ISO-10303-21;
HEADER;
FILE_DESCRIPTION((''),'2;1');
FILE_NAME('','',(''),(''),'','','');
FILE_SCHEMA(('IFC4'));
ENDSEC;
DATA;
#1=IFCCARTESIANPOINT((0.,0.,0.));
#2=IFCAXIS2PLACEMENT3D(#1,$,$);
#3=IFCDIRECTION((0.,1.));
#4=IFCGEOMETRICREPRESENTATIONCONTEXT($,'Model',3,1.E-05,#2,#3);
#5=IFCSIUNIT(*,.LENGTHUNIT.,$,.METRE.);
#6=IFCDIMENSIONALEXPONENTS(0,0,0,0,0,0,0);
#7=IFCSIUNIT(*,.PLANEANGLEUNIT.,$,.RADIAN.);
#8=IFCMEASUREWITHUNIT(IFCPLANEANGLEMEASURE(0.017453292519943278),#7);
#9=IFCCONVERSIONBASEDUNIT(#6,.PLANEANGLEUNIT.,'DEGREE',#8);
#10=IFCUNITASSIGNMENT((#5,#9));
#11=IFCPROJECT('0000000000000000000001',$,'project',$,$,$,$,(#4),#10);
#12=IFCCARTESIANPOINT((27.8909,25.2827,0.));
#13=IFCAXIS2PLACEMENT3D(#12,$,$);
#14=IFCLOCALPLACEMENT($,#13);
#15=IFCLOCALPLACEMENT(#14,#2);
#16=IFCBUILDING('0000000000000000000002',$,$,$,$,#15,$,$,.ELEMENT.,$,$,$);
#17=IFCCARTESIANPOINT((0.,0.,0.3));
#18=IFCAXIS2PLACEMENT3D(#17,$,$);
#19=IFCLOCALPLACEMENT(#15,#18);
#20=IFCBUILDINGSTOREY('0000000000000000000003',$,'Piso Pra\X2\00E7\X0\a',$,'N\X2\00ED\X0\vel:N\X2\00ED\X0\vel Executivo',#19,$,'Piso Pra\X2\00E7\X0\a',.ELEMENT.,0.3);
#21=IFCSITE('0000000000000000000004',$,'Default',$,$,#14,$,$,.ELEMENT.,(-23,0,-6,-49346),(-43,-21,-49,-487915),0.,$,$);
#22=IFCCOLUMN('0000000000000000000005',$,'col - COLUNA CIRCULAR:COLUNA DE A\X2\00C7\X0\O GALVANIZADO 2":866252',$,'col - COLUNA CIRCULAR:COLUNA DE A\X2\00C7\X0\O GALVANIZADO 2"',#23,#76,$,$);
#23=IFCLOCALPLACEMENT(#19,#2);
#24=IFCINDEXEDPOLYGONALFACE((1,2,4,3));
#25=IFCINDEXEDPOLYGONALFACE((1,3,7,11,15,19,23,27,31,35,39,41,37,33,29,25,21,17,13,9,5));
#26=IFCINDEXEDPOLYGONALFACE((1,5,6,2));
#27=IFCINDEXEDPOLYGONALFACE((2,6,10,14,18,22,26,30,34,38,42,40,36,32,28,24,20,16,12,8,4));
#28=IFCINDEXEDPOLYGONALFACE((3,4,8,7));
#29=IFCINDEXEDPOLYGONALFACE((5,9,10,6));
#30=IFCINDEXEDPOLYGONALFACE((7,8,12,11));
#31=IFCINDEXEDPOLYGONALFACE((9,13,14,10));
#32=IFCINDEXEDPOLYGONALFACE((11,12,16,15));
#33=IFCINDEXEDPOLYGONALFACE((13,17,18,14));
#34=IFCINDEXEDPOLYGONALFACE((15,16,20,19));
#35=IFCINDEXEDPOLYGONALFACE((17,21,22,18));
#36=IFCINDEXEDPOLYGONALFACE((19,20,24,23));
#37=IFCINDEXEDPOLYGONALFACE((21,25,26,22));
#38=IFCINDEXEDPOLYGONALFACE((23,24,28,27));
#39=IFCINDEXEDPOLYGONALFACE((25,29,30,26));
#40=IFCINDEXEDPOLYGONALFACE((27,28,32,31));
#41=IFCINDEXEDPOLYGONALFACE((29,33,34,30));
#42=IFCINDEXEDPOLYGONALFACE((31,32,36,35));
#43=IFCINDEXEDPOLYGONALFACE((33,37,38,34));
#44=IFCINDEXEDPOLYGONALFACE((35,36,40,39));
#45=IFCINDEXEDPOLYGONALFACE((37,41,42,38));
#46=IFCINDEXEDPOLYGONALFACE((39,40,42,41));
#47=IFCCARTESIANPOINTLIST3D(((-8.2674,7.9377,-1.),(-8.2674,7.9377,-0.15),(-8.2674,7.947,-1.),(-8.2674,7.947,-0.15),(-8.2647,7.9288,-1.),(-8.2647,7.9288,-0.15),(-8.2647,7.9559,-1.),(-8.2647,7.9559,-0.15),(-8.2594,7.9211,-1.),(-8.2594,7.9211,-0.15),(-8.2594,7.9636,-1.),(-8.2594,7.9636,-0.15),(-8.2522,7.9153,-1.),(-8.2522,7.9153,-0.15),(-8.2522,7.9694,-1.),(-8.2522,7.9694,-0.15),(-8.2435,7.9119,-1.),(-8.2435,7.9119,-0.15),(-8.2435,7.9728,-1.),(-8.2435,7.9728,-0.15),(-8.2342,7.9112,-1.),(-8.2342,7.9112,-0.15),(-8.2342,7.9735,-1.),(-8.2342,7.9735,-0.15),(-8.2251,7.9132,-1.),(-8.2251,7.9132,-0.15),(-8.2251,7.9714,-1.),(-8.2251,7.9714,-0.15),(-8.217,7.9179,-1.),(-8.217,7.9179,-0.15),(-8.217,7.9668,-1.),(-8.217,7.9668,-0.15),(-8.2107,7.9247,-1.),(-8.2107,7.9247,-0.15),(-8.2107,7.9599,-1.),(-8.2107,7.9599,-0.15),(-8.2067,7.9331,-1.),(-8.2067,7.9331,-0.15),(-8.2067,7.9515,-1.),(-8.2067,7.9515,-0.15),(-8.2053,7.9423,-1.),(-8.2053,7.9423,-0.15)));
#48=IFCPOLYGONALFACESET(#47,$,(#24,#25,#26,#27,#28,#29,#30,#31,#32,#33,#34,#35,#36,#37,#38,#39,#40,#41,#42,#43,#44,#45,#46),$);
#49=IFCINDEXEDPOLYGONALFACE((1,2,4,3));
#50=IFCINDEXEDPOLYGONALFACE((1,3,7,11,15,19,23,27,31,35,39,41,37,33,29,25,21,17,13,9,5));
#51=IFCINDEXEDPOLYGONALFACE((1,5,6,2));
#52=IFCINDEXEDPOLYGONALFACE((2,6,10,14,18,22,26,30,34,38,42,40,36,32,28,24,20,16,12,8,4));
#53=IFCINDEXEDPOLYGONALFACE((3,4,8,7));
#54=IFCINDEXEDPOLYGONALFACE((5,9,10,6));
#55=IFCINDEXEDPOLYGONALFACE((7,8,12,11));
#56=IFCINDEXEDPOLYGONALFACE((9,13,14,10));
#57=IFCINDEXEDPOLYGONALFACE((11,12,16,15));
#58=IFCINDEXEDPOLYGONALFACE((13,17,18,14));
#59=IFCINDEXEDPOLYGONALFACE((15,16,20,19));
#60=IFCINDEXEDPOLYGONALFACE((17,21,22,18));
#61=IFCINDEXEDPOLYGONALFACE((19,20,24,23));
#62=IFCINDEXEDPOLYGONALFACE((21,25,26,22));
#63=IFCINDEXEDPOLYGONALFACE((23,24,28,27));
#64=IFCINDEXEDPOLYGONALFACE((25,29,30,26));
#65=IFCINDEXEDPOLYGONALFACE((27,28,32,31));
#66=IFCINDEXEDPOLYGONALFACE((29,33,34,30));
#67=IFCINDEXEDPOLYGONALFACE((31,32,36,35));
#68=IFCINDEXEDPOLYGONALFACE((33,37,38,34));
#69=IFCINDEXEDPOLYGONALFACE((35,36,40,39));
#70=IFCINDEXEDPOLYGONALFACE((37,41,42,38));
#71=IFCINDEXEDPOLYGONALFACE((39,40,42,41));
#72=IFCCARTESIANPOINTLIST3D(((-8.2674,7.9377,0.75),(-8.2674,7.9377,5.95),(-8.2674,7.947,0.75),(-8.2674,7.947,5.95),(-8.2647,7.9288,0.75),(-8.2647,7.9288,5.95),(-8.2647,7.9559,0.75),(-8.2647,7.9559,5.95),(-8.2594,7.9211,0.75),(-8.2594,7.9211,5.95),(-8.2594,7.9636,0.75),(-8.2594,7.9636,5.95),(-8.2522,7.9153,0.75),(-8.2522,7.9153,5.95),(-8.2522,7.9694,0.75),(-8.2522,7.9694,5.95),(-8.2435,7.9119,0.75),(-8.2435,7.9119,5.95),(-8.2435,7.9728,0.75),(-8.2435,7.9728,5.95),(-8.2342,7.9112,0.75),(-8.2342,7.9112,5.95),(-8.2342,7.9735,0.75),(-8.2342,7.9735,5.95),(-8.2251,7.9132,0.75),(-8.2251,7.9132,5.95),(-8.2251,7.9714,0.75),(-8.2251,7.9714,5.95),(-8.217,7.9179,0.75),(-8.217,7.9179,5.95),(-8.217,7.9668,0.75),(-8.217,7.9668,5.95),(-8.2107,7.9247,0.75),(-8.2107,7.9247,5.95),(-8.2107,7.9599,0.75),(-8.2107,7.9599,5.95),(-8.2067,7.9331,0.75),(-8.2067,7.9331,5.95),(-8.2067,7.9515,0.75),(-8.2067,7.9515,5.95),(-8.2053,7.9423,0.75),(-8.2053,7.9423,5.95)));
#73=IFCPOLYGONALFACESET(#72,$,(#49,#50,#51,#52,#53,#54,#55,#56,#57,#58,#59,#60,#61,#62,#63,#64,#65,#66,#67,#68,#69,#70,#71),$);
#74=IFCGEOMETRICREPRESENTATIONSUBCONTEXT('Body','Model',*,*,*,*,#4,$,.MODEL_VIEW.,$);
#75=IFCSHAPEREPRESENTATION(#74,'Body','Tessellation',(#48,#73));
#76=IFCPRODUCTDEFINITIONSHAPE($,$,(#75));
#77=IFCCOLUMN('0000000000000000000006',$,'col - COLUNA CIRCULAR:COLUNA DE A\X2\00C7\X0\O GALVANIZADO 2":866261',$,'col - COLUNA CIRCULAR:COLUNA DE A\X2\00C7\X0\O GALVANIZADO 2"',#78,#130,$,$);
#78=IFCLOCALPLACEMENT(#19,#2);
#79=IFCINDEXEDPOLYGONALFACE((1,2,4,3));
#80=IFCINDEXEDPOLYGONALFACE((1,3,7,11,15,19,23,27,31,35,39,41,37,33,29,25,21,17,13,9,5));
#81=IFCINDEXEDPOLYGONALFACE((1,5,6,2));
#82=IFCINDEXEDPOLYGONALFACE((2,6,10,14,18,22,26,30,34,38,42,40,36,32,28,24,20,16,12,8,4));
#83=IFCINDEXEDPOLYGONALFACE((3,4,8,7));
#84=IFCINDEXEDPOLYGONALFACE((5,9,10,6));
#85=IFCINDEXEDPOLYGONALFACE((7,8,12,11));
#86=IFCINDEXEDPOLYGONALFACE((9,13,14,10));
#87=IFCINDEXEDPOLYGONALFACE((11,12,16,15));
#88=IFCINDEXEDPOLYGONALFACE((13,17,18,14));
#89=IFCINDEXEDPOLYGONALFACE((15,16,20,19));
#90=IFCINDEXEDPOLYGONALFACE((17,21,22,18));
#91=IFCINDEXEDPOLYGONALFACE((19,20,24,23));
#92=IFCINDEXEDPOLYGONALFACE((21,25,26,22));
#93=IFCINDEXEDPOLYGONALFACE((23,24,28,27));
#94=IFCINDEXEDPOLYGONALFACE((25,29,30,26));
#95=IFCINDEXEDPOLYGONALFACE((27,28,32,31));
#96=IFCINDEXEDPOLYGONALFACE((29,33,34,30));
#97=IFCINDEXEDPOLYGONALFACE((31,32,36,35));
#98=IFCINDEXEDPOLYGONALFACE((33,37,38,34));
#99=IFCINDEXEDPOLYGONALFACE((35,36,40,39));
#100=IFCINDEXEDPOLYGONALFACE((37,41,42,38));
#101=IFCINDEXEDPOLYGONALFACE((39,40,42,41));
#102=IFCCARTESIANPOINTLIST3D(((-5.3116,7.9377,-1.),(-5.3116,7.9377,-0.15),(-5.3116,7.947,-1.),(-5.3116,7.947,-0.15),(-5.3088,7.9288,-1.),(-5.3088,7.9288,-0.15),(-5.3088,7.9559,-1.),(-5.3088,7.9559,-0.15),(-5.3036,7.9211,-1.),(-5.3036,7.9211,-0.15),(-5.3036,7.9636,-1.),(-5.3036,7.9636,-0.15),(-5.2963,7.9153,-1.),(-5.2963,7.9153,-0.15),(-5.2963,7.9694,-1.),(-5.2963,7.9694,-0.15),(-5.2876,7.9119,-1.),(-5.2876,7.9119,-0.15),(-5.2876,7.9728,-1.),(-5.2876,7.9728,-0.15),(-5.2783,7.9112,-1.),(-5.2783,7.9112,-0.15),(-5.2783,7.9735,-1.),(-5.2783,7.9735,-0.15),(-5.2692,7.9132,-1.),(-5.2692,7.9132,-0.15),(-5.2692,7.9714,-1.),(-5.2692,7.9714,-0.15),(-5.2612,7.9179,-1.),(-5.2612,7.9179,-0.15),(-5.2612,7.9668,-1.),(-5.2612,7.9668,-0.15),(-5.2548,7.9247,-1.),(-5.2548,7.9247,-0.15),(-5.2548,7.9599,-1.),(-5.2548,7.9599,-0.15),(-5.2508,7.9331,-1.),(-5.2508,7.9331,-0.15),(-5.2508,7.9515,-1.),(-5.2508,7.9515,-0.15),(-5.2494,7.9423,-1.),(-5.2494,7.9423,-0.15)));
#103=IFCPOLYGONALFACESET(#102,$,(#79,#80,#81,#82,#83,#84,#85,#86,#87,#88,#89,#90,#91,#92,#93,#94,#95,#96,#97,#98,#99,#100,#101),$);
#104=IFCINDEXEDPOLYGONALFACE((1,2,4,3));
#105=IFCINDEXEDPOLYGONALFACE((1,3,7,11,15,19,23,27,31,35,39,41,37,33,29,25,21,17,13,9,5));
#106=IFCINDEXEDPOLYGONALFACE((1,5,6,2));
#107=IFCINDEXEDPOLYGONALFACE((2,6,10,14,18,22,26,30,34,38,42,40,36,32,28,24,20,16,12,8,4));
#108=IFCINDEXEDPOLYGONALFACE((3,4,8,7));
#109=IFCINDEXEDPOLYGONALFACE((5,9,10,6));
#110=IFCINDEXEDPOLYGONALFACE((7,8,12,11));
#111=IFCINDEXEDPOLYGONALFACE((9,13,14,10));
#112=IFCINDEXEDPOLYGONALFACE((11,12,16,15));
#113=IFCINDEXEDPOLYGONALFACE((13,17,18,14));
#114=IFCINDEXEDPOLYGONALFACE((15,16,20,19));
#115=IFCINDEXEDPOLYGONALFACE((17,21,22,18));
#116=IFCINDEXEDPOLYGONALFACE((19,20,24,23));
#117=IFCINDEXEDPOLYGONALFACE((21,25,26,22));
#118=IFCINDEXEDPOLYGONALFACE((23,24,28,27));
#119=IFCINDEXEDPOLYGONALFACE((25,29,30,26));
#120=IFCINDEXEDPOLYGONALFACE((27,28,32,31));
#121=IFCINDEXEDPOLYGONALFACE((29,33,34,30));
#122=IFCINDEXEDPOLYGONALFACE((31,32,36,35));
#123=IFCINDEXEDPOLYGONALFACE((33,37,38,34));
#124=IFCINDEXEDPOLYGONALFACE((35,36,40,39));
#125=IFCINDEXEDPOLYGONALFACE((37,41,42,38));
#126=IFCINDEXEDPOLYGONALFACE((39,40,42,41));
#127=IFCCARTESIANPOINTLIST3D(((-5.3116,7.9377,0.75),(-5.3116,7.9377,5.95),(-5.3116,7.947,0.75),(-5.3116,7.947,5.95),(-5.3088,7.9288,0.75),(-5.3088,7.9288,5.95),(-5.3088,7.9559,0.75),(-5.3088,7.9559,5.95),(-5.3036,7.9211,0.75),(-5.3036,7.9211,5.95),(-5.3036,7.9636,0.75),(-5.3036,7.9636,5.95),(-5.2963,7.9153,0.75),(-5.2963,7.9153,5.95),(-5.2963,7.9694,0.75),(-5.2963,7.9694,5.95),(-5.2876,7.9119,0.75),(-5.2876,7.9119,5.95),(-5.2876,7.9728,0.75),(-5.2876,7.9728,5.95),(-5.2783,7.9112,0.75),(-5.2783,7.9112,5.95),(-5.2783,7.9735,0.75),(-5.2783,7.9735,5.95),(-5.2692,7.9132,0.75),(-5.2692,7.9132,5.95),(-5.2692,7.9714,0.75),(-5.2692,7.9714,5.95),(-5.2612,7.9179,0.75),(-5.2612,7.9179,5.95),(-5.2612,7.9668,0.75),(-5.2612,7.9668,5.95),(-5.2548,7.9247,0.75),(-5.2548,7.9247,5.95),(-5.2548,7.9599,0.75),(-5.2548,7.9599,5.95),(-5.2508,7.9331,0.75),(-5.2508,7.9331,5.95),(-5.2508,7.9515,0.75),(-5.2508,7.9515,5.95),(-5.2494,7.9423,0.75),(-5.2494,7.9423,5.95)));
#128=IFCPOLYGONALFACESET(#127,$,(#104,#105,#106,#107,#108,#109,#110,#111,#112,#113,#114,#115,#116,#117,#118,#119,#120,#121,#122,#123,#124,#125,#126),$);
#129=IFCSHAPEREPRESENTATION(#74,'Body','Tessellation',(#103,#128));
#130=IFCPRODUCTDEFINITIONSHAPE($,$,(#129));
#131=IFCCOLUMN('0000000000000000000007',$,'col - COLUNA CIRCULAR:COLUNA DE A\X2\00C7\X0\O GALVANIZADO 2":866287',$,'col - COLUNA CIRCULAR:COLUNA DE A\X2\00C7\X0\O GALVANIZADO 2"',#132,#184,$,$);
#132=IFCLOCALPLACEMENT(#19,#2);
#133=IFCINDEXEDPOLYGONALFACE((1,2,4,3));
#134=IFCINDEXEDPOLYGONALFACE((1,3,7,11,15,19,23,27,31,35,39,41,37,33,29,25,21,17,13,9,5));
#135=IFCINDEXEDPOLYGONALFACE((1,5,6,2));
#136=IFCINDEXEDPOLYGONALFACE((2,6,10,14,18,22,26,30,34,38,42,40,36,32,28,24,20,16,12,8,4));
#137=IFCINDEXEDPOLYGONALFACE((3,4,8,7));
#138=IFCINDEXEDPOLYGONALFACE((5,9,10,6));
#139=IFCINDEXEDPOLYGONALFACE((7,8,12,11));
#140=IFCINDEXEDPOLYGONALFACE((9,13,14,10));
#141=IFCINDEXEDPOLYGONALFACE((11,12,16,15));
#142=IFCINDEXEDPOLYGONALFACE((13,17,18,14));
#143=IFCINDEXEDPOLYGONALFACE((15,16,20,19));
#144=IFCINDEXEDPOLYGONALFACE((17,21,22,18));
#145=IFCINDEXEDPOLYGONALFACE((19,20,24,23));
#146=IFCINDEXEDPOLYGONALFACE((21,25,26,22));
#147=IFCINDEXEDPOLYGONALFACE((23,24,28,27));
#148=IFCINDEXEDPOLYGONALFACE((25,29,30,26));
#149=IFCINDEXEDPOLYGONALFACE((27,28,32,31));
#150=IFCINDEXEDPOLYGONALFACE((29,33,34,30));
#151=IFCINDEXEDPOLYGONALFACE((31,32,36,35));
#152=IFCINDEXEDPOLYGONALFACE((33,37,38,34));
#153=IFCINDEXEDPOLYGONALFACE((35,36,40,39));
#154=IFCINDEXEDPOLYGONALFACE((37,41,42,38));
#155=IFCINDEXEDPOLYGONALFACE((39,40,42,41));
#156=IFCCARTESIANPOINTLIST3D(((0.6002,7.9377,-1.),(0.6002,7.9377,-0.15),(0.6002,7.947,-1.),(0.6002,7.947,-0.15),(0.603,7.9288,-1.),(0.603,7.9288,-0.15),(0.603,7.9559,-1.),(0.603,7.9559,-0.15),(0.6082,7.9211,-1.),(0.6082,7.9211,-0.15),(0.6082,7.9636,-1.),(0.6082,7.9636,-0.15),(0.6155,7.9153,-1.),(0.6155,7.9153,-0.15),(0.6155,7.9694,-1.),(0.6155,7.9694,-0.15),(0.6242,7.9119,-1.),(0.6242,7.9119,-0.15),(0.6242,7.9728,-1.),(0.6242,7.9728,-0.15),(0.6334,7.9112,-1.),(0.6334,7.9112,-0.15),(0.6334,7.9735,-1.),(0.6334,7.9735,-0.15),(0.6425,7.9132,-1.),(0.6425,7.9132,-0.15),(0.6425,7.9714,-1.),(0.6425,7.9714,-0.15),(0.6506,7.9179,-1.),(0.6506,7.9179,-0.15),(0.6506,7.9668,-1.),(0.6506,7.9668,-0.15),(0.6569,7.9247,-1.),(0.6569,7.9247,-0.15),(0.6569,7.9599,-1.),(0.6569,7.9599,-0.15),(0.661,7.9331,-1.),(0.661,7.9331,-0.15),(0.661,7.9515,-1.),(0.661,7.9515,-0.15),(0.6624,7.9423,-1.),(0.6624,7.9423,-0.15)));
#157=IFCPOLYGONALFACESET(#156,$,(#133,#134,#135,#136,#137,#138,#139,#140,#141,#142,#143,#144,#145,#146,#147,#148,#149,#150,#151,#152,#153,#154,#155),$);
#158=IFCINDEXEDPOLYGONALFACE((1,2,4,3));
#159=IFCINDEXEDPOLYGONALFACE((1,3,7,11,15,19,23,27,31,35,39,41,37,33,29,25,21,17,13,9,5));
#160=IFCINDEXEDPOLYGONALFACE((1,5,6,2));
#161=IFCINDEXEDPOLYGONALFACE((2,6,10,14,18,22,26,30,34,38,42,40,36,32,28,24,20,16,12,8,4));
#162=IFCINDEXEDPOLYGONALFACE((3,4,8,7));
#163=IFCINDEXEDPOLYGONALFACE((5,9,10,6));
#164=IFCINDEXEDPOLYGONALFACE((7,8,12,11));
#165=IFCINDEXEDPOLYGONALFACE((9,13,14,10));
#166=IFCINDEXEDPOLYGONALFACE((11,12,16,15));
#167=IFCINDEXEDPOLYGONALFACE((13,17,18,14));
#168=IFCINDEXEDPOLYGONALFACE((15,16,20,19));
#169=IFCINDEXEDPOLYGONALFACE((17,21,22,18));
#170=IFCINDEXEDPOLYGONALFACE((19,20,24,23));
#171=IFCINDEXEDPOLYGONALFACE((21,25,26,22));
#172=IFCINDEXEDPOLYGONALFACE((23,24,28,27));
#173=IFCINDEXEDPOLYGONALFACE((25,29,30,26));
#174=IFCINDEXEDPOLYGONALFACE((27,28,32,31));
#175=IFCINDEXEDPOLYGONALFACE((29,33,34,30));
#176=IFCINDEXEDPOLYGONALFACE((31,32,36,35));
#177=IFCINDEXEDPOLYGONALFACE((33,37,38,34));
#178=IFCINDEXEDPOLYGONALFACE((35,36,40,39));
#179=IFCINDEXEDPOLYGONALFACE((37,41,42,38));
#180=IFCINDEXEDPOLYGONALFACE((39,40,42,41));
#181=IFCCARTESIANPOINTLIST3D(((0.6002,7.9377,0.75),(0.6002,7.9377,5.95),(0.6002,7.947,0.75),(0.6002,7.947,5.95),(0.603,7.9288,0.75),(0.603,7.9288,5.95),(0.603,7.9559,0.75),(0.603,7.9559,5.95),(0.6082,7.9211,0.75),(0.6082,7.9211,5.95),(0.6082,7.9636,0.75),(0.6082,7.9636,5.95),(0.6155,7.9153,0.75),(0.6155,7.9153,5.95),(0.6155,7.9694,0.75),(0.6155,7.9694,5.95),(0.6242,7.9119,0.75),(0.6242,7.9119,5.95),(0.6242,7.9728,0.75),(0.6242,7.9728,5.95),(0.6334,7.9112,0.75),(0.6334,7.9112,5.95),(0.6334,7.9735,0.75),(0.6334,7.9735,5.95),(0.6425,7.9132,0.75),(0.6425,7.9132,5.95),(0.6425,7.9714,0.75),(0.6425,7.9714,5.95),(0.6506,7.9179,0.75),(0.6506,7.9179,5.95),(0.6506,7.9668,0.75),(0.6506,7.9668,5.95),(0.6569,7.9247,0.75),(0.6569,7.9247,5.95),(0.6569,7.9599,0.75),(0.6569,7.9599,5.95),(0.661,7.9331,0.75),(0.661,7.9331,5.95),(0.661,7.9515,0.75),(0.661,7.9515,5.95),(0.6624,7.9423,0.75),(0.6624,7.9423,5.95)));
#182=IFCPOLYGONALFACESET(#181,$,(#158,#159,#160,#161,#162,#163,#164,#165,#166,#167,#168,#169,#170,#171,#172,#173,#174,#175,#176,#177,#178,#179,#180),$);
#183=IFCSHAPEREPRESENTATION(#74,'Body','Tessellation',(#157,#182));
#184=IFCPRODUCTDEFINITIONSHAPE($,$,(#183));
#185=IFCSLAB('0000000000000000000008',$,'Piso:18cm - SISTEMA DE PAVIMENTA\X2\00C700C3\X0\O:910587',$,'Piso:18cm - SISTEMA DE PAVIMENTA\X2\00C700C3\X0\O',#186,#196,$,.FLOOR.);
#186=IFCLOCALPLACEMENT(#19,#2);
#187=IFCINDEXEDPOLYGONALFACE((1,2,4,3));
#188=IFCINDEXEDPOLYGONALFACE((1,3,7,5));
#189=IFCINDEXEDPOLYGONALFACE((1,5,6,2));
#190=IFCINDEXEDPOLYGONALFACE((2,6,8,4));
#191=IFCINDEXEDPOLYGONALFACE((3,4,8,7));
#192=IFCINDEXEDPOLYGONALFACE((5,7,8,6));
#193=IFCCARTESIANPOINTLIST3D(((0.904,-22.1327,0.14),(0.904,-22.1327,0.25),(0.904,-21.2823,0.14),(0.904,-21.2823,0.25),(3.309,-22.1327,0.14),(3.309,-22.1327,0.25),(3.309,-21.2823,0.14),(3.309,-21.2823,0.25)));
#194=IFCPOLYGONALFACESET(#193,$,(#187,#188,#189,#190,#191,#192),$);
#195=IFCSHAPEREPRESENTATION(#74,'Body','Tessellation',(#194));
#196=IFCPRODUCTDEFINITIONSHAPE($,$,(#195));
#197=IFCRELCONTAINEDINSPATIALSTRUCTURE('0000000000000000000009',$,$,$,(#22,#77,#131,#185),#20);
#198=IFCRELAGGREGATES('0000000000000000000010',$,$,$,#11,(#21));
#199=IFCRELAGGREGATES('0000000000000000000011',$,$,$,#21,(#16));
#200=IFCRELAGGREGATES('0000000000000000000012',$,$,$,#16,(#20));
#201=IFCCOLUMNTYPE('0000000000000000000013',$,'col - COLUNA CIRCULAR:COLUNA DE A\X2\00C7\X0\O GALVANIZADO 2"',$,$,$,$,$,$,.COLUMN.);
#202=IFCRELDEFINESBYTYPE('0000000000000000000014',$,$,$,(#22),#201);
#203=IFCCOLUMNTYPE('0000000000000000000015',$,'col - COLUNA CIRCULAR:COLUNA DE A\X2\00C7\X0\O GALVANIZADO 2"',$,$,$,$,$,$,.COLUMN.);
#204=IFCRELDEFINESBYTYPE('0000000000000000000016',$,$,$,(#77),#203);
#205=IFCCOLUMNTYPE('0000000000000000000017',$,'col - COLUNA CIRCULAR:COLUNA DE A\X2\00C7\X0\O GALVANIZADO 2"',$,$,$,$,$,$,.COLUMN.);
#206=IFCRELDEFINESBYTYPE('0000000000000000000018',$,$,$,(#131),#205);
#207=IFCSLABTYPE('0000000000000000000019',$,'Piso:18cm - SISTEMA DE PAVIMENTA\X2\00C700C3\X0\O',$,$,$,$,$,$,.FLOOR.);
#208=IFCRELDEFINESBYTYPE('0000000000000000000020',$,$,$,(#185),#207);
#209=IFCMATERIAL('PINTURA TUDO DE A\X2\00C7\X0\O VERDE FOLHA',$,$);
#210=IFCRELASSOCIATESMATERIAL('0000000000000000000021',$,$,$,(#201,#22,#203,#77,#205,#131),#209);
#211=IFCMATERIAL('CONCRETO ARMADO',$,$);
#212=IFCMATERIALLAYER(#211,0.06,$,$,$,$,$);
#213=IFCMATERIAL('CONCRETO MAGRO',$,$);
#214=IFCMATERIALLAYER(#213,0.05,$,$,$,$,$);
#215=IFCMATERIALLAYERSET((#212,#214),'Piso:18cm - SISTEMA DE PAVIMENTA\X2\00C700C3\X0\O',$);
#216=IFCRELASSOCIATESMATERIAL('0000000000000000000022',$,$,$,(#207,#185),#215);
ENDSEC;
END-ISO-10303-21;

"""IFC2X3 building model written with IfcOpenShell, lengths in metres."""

from ifc_helpers import new_model, entity, si_unit, converted_unit, direction, frame, frame_2d, origin, origin_2d_with_axis, place, context, subcontext, project, spatial, rectangle, circle, extrude, source, transform, mapped, material, layer, layer_set, layer_usage, type_object, type_shapes, element, save


model = new_model("IFC2X3")

# Units and contexts
model_context = context("Model", 3, precision=1e-05, world=origin(), true_north=direction((0.0, 1.0)))
body_context = subcontext(model_context, "Body", "Model", "MODEL_VIEW")
ifc_project = project(units=[si_unit("LENGTHUNIT", "METRE"), converted_unit("PLANEANGLEUNIT", "DEGREE", entity("IfcPlaneAngleMeasure", 0.017453292519943278), si_unit("PLANEANGLEUNIT", "RADIAN"), dimensions=[0, 0, 0, 0, 0, 0, 0])], contexts=[model_context])

# Site, building, storey
site_placement = place(None, frame((27.8909, 25.2827, 0.0)))
site = spatial("IfcSite", under=ifc_project, at=site_placement, Name="Default", CompositionType="ELEMENT", RefLatitude=(-23, 0, -6, -49346), RefLongitude=(-43, -21, -49, -487915), RefElevation=0.0)
building_placement = place(site_placement, origin())
building = spatial("IfcBuilding", under=site, at=building_placement, CompositionType="ELEMENT")
storey_placement = place(building_placement, frame((0.0, 0.0, 0.3)))
storey = spatial("IfcBuildingStorey", under=building, at=storey_placement, Name="Piso Praça", ObjectType="Nível:Nível Executivo", LongName="Piso Praça", CompositionType="ELEMENT", Elevation=0.3)

# Columns
ifc_material_1 = material(Name="PINTURA TUDO DE AÇO VERDE FOLHA")
column_type_1 = type_object("IfcColumnType", Name="col - COLUNA CIRCULAR:COLUNA DE AÇO GALVANIZADO 2\"", PredefinedType="COLUMN", material=ifc_material_1)
shared_shape_1 = source(origin(), body_context, "Body", "SweptSolid", [
    extrude(circle(Radius=0.0312, at=origin_2d_with_axis()), frame((-8.2365, 7.9423, -0.7)), (0.0, 0.0, 1.0), 0.85),
    extrude(circle(Radius=0.0312, at=origin_2d_with_axis()), frame((-8.2365, 7.9423, 1.05)), (0.0, 0.0, 1.0), 5.2),
])
type_shapes(column_type_1, [shared_shape_1])
column_1_placement = place(storey_placement, frame((0.0, 0.0, -0.3)))
element("IfcColumn", 1, at=column_1_placement, inside=storey, type_object=column_type_1, material=ifc_material_1, Name="col - COLUNA CIRCULAR:COLUNA DE AÇO GALVANIZADO 2\":866252", ObjectType="col - COLUNA CIRCULAR:COLUNA DE AÇO GALVANIZADO 2\"", context=body_context, shape_type="MappedRepresentation", body=[
    mapped(shared_shape_1, transform((0.0, 0.0, 0.0), scale=1.0)),
])
column_type_2 = type_object("IfcColumnType", Name="col - COLUNA CIRCULAR:COLUNA DE AÇO GALVANIZADO 2\"", PredefinedType="COLUMN", material=ifc_material_1)
shared_shape_2 = source(origin(), body_context, "Body", "SweptSolid", [
    extrude(circle(Radius=0.0312, at=origin_2d_with_axis()), frame((-5.2807, 7.9423, -0.7)), (0.0, 0.0, 1.0), 0.85),
    extrude(circle(Radius=0.0312, at=origin_2d_with_axis()), frame((-5.2807, 7.9423, 1.05)), (0.0, 0.0, 1.0), 5.2),
])
type_shapes(column_type_2, [shared_shape_2])
column_2_placement = place(storey_placement, frame((0.0, 0.0, -0.3)))
element("IfcColumn", 2, at=column_2_placement, inside=storey, type_object=column_type_2, material=ifc_material_1, Name="col - COLUNA CIRCULAR:COLUNA DE AÇO GALVANIZADO 2\":866261", ObjectType="col - COLUNA CIRCULAR:COLUNA DE AÇO GALVANIZADO 2\"", context=body_context, shape_type="MappedRepresentation", body=[
    mapped(shared_shape_2, transform((0.0, 0.0, 0.0), scale=1.0)),
])
column_type_3 = type_object("IfcColumnType", Name="col - COLUNA CIRCULAR:COLUNA DE AÇO GALVANIZADO 2\"", PredefinedType="COLUMN", material=ifc_material_1)
shared_shape_3 = source(origin(), body_context, "Body", "SweptSolid", [
    extrude(circle(Radius=0.0312, at=origin_2d_with_axis()), frame((0.6311, 7.9423, -0.7)), (0.0, 0.0, 1.0), 0.85),
    extrude(circle(Radius=0.0312, at=origin_2d_with_axis()), frame((0.6311, 7.9423, 1.05)), (0.0, 0.0, 1.0), 5.2),
])
type_shapes(column_type_3, [shared_shape_3])
column_3_placement = place(storey_placement, frame((0.0, 0.0, -0.3)))
element("IfcColumn", 3, at=column_3_placement, inside=storey, type_object=column_type_3, material=ifc_material_1, Name="col - COLUNA CIRCULAR:COLUNA DE AÇO GALVANIZADO 2\":866287", ObjectType="col - COLUNA CIRCULAR:COLUNA DE AÇO GALVANIZADO 2\"", context=body_context, shape_type="MappedRepresentation", body=[
    mapped(shared_shape_3, transform((0.0, 0.0, 0.0), scale=1.0)),
])

# Slab
ifc_material_2 = material(Name="CONCRETO ARMADO")
ifc_layer_1 = layer(ifc_material_2, 0.06)
ifc_material_3 = material(Name="CONCRETO MAGRO")
ifc_layer_2 = layer(ifc_material_3, 0.05)
ifc_layer_set_1 = layer_set([ifc_layer_1, ifc_layer_2], Name="Piso:18cm - SISTEMA DE PAVIMENTAÇÃO")
ifc_layer_usage_1 = layer_usage(ifc_layer_set_1, "AXIS3", "POSITIVE", 0.0)
slab_type = type_object("IfcSlabType", Name="Piso:18cm - SISTEMA DE PAVIMENTAÇÃO", PredefinedType="FLOOR", material=ifc_layer_set_1)
slab_1_placement = place(storey_placement, origin())
element("IfcSlab", 4, at=slab_1_placement, inside=storey, type_object=slab_type, material=ifc_layer_usage_1, Name="Piso:18cm - SISTEMA DE PAVIMENTAÇÃO:910587", ObjectType="Piso:18cm - SISTEMA DE PAVIMENTAÇÃO", PredefinedType="FLOOR", context=body_context, shape_type="SweptSolid", body=[
    extrude(rectangle(XDim=0.8504, YDim=2.405, at=frame_2d((0.0, 0.0), x_axis=(1.0, 0.0))), frame((2.1065, -21.7075, 0.25), z_axis=(0.0, 0.0, -1.0), x_axis=(0.0, 1.0, 0.0)), (0.0, 0.0, 1.0), 0.11),
])

save(model, "model.ifc")
